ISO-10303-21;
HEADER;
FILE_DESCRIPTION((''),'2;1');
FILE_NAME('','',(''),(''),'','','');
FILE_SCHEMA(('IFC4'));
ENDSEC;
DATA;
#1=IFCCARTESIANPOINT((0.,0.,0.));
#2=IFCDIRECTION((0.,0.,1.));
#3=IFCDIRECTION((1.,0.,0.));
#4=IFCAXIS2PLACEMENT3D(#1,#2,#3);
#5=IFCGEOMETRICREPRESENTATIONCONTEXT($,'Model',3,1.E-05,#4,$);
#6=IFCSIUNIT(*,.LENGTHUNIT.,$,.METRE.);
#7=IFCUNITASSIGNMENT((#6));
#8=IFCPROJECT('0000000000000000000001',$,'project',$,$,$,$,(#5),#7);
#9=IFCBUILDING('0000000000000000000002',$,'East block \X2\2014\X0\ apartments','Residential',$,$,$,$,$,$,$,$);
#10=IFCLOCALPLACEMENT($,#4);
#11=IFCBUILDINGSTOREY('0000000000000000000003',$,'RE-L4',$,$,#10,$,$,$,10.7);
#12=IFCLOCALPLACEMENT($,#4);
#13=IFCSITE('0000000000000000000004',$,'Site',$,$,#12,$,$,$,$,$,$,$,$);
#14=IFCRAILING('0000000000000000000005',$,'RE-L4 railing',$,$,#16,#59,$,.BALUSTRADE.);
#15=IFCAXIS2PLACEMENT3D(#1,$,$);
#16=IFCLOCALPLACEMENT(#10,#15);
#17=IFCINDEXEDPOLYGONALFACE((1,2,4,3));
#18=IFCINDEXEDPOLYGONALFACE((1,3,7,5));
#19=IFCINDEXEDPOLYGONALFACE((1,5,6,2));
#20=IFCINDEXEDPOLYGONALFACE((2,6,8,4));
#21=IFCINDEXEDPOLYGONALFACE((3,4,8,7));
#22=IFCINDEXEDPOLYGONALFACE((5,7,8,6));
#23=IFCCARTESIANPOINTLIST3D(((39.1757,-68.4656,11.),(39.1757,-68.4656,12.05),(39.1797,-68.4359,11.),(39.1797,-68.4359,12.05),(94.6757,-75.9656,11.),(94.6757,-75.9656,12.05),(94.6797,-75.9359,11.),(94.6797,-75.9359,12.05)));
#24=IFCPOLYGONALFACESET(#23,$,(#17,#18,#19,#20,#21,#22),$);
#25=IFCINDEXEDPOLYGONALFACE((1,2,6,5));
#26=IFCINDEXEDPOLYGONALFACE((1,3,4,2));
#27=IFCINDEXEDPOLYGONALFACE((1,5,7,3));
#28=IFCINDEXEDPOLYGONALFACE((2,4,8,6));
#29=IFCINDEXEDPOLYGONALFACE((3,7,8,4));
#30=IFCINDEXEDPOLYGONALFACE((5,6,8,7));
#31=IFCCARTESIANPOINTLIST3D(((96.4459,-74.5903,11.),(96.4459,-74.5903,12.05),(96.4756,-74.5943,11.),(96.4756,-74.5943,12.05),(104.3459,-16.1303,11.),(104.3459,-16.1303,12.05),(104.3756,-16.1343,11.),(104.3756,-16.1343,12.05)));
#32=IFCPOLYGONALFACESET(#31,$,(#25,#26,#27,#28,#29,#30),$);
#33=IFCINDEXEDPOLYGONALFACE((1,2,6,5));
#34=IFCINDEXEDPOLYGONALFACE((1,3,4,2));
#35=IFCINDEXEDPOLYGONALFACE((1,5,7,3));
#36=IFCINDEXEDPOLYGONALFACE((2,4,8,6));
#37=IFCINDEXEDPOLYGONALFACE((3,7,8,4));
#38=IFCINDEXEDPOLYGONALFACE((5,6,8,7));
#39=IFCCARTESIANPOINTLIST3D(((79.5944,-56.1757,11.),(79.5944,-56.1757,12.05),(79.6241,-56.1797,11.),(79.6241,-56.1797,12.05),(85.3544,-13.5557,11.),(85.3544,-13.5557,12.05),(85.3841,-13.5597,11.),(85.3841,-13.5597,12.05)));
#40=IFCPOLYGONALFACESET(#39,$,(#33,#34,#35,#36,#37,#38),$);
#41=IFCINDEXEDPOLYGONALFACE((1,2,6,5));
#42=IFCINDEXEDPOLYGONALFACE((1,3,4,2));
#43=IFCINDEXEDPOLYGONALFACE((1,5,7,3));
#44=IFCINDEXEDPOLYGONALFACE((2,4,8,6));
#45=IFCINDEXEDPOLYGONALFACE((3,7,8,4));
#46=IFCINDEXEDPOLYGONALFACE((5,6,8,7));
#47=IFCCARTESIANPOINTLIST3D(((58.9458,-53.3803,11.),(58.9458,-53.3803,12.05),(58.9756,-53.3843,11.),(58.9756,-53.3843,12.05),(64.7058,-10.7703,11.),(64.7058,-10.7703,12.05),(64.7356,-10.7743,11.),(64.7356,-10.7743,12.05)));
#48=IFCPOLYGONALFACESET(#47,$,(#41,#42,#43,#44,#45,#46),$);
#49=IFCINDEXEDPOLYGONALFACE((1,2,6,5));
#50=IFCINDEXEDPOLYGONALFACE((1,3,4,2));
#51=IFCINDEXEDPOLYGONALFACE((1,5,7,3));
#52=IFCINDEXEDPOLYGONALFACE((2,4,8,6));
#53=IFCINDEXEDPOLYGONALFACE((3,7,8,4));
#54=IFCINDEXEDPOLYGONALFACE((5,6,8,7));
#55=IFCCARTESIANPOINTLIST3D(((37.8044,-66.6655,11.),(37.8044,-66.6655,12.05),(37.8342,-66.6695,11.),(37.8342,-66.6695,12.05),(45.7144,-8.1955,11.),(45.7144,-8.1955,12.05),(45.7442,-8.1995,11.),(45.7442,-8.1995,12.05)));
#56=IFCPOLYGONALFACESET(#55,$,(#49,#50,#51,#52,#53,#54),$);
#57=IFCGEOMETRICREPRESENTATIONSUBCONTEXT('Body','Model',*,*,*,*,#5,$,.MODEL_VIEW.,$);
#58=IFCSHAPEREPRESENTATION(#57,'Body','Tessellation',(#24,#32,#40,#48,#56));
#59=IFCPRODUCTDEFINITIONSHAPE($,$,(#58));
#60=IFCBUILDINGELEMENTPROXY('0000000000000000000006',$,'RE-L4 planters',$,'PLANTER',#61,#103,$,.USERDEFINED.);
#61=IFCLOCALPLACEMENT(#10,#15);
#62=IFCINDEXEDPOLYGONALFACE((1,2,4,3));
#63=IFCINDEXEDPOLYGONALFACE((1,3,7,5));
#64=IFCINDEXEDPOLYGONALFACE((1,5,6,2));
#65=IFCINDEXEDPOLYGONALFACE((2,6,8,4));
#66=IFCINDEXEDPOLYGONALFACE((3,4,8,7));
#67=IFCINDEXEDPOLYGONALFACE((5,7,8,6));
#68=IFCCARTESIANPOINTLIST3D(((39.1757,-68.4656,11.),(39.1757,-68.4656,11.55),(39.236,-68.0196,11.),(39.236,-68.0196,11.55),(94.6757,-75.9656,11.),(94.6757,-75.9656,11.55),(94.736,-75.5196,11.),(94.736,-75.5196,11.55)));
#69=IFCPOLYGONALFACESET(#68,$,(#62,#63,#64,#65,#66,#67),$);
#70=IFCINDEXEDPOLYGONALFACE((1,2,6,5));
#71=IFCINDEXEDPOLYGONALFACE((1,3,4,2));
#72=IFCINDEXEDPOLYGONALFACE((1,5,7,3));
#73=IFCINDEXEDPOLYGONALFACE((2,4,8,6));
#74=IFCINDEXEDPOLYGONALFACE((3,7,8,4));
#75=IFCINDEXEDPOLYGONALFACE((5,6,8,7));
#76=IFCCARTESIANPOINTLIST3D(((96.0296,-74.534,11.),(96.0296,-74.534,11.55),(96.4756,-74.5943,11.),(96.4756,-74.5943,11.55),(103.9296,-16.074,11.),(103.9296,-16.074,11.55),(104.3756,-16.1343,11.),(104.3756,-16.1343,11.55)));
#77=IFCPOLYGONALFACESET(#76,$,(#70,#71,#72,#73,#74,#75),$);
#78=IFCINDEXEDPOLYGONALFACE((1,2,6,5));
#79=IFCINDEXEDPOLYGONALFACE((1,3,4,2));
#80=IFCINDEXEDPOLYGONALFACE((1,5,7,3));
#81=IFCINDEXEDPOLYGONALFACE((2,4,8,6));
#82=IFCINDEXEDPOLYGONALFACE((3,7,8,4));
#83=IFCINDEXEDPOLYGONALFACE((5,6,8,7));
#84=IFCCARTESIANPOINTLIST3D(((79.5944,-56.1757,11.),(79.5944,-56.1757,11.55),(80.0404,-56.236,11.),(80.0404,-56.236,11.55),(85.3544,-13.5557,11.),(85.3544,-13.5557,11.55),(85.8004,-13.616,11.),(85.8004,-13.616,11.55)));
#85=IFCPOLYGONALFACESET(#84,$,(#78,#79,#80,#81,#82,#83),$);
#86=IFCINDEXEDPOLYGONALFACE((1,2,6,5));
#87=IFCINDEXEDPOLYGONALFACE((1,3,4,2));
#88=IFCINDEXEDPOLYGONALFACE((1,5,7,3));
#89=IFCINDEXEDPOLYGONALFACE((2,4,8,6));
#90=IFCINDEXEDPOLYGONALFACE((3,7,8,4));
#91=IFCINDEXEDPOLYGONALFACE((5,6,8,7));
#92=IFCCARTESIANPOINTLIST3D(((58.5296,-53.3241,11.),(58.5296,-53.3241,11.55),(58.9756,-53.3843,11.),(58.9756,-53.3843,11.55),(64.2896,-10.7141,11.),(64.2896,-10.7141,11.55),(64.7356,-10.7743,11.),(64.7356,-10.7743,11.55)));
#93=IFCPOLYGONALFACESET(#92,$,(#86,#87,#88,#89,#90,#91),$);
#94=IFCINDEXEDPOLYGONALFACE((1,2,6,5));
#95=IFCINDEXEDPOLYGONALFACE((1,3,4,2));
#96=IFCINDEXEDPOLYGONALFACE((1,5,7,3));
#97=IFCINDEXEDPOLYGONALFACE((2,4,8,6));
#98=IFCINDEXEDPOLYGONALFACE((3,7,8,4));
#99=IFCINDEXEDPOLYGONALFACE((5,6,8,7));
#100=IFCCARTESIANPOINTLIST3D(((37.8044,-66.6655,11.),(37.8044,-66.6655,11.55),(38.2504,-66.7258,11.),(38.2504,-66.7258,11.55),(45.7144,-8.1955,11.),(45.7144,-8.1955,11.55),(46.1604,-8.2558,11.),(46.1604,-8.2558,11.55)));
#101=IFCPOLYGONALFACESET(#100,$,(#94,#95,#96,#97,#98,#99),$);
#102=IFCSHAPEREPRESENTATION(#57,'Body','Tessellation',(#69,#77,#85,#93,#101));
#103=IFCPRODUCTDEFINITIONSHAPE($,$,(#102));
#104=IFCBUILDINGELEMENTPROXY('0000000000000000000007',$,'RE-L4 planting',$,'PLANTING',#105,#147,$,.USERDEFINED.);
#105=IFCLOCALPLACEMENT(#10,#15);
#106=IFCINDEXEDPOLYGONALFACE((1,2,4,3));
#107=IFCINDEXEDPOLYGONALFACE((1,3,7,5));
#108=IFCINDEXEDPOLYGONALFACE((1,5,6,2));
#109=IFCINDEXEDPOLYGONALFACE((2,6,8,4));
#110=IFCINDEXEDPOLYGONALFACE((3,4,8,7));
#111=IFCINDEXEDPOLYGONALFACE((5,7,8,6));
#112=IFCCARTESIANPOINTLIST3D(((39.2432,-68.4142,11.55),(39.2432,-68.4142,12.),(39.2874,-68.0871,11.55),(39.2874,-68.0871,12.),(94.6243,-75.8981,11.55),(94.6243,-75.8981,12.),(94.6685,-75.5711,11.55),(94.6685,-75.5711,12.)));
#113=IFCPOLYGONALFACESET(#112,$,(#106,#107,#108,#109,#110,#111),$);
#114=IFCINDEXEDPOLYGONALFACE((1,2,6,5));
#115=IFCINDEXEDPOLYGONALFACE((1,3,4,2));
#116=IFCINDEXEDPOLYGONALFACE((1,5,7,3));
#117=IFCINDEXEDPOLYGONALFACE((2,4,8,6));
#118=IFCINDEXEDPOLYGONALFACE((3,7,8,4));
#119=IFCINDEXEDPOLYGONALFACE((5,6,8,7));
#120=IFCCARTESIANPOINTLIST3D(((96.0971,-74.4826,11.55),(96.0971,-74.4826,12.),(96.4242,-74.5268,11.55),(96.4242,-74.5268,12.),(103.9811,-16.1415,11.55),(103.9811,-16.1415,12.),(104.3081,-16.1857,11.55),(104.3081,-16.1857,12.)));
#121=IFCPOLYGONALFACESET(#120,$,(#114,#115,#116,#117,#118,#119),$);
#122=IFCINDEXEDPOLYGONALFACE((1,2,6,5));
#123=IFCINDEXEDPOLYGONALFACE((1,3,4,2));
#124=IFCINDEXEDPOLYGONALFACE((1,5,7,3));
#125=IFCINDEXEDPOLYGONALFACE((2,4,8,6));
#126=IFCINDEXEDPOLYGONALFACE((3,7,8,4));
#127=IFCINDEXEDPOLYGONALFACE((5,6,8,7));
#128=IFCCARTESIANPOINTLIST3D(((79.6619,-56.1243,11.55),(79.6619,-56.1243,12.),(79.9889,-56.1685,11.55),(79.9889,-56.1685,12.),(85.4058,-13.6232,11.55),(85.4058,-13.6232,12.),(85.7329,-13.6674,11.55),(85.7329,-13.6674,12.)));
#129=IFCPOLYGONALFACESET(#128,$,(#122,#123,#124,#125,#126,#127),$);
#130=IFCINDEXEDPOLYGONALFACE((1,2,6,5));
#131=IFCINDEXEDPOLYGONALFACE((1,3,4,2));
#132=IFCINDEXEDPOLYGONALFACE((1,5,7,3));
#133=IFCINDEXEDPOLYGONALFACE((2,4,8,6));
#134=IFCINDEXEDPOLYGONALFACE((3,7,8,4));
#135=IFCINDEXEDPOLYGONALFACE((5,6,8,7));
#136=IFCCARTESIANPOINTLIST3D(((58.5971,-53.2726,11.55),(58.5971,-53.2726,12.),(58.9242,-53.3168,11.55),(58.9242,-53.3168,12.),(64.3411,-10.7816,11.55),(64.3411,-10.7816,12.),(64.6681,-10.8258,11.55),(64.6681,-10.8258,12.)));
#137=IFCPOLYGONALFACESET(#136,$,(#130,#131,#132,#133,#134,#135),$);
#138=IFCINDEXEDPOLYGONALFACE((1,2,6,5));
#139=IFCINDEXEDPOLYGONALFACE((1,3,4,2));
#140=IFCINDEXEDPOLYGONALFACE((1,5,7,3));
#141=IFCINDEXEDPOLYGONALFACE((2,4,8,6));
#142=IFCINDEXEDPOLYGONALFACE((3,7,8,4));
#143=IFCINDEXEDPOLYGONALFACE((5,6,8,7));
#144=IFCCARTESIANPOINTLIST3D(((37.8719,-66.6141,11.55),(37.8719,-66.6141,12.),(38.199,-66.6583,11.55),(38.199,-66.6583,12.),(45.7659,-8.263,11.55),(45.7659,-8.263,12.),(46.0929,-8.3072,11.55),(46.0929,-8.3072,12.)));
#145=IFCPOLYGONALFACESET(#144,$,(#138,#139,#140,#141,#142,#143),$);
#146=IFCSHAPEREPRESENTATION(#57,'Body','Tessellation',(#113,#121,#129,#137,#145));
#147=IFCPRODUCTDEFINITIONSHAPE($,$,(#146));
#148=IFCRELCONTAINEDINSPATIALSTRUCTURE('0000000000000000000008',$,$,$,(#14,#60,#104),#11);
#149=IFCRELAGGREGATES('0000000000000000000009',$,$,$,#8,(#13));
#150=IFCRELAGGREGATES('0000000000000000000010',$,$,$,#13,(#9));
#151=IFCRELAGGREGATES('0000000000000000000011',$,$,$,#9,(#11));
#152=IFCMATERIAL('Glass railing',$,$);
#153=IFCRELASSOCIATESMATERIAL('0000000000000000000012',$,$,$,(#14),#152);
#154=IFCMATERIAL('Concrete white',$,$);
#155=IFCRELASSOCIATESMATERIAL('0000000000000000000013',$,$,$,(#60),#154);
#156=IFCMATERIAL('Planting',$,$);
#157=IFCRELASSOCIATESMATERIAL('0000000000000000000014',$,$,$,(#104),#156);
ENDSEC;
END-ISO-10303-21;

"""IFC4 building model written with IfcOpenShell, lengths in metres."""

from ifc_helpers import new_model, si_unit, frame, origin_with_axes, place, context, subcontext, project, spatial, polyline, outline, extrude, material, element, save


model = new_model("IFC4")

# Units and contexts
model_context = context("Model", 3, precision=1e-05, world=origin_with_axes())
body_context = subcontext(model_context, "Body", "Model", "MODEL_VIEW")
ifc_project = project(units=[si_unit("LENGTHUNIT", "METRE")], contexts=[model_context])

# Site, building, storey
site_placement = place(None, origin_with_axes())
site = spatial("IfcSite", under=ifc_project, at=site_placement, Name="Site")
building = spatial("IfcBuilding", under=site, Name="East block — apartments", Description="Residential")
storey_placement = place(None, origin_with_axes())
storey = spatial("IfcBuildingStorey", under=building, at=storey_placement, Name="RE-L4", Elevation=10.7)

# Railing
ifc_material_1 = material(Name="Glass railing")
railing_placement = place(storey_placement, origin_with_axes())
element("IfcRailing", 1, at=railing_placement, inside=storey, material=ifc_material_1, Name="RE-L4 railing", PredefinedType="BALUSTRADE", context=body_context, shape_type="SweptSolid", body=[
    extrude(outline(polyline([(39.1757, -68.4656), (94.6757, -75.9656), (94.6797, -75.9359), (39.1797, -68.4359), (39.1757, -68.4656)])), frame((0.0, 0.0, 11.0), z_axis=(0.0, 0.0, 1.0), x_axis=(1.0, 0.0, 0.0)), (0.0, 0.0, 1.0), 1.05),
    extrude(outline(polyline([(96.4756, -74.5943), (104.3756, -16.1343), (104.3459, -16.1303), (96.4459, -74.5903), (96.4756, -74.5943)])), frame((0.0, 0.0, 11.0), z_axis=(0.0, 0.0, 1.0), x_axis=(1.0, 0.0, 0.0)), (0.0, 0.0, 1.0), 1.05),
    extrude(outline(polyline([(85.3544, -13.5557), (79.5944, -56.1757), (79.6241, -56.1797), (85.3841, -13.5597), (85.3544, -13.5557)])), frame((0.0, 0.0, 11.0), z_axis=(0.0, 0.0, 1.0), x_axis=(1.0, 0.0, 0.0)), (0.0, 0.0, 1.0), 1.05),
    extrude(outline(polyline([(58.9756, -53.3843), (64.7356, -10.7743), (64.7058, -10.7703), (58.9458, -53.3803), (58.9756, -53.3843)])), frame((0.0, 0.0, 11.0), z_axis=(0.0, 0.0, 1.0), x_axis=(1.0, 0.0, 0.0)), (0.0, 0.0, 1.0), 1.05),
    extrude(outline(polyline([(45.7144, -8.1955), (37.8044, -66.6655), (37.8342, -66.6695), (45.7442, -8.1995), (45.7144, -8.1955)])), frame((0.0, 0.0, 11.0), z_axis=(0.0, 0.0, 1.0), x_axis=(1.0, 0.0, 0.0)), (0.0, 0.0, 1.0), 1.05),
])

# Building element proxies
ifc_material_2 = material(Name="Concrete white")
proxy_1_placement = place(storey_placement, origin_with_axes())
element("IfcBuildingElementProxy", 2, at=proxy_1_placement, inside=storey, material=ifc_material_2, Name="RE-L4 planters", ObjectType="PLANTER", PredefinedType="USERDEFINED", context=body_context, shape_type="SweptSolid", body=[
    extrude(outline(polyline([(39.1757, -68.4656), (94.6757, -75.9656), (94.736, -75.5196), (39.236, -68.0196), (39.1757, -68.4656)])), frame((0.0, 0.0, 11.0), z_axis=(0.0, 0.0, 1.0), x_axis=(1.0, 0.0, 0.0)), (0.0, 0.0, 1.0), 0.55),
    extrude(outline(polyline([(96.4756, -74.5943), (104.3756, -16.1343), (103.9296, -16.074), (96.0296, -74.534), (96.4756, -74.5943)])), frame((0.0, 0.0, 11.0), z_axis=(0.0, 0.0, 1.0), x_axis=(1.0, 0.0, 0.0)), (0.0, 0.0, 1.0), 0.55),
    extrude(outline(polyline([(85.3544, -13.5557), (79.5944, -56.1757), (80.0404, -56.236), (85.8004, -13.616), (85.3544, -13.5557)])), frame((0.0, 0.0, 11.0), z_axis=(0.0, 0.0, 1.0), x_axis=(1.0, 0.0, 0.0)), (0.0, 0.0, 1.0), 0.55),
    extrude(outline(polyline([(58.9756, -53.3843), (64.7356, -10.7743), (64.2896, -10.7141), (58.5296, -53.3241), (58.9756, -53.3843)])), frame((0.0, 0.0, 11.0), z_axis=(0.0, 0.0, 1.0), x_axis=(1.0, 0.0, 0.0)), (0.0, 0.0, 1.0), 0.55),
    extrude(outline(polyline([(45.7144, -8.1955), (37.8044, -66.6655), (38.2504, -66.7258), (46.1604, -8.2558), (45.7144, -8.1955)])), frame((0.0, 0.0, 11.0), z_axis=(0.0, 0.0, 1.0), x_axis=(1.0, 0.0, 0.0)), (0.0, 0.0, 1.0), 0.55),
])
ifc_material_3 = material(Name="Planting")
proxy_2_placement = place(storey_placement, origin_with_axes())
element("IfcBuildingElementProxy", 3, at=proxy_2_placement, inside=storey, material=ifc_material_3, Name="RE-L4 planting", ObjectType="PLANTING", PredefinedType="USERDEFINED", context=body_context, shape_type="SweptSolid", body=[
    extrude(outline(polyline([(39.2432, -68.4142), (94.6243, -75.8981), (94.6685, -75.5711), (39.2874, -68.0871), (39.2432, -68.4142)])), frame((0.0, 0.0, 11.55), z_axis=(0.0, 0.0, 1.0), x_axis=(1.0, 0.0, 0.0)), (0.0, 0.0, 1.0), 0.45),
    extrude(outline(polyline([(96.4242, -74.5268), (104.3081, -16.1857), (103.9811, -16.1415), (96.0971, -74.4826), (96.4242, -74.5268)])), frame((0.0, 0.0, 11.55), z_axis=(0.0, 0.0, 1.0), x_axis=(1.0, 0.0, 0.0)), (0.0, 0.0, 1.0), 0.45),
    extrude(outline(polyline([(85.4058, -13.6232), (79.6619, -56.1243), (79.9889, -56.1685), (85.7329, -13.6674), (85.4058, -13.6232)])), frame((0.0, 0.0, 11.55), z_axis=(0.0, 0.0, 1.0), x_axis=(1.0, 0.0, 0.0)), (0.0, 0.0, 1.0), 0.45),
    extrude(outline(polyline([(58.9242, -53.3168), (64.6681, -10.8258), (64.3411, -10.7816), (58.5971, -53.2726), (58.9242, -53.3168)])), frame((0.0, 0.0, 11.55), z_axis=(0.0, 0.0, 1.0), x_axis=(1.0, 0.0, 0.0)), (0.0, 0.0, 1.0), 0.45),
    extrude(outline(polyline([(45.7659, -8.263), (37.8719, -66.6141), (38.199, -66.6583), (46.0929, -8.3072), (45.7659, -8.263)])), frame((0.0, 0.0, 11.55), z_axis=(0.0, 0.0, 1.0), x_axis=(1.0, 0.0, 0.0)), (0.0, 0.0, 1.0), 0.45),
])

save(model, "model.ifc")
